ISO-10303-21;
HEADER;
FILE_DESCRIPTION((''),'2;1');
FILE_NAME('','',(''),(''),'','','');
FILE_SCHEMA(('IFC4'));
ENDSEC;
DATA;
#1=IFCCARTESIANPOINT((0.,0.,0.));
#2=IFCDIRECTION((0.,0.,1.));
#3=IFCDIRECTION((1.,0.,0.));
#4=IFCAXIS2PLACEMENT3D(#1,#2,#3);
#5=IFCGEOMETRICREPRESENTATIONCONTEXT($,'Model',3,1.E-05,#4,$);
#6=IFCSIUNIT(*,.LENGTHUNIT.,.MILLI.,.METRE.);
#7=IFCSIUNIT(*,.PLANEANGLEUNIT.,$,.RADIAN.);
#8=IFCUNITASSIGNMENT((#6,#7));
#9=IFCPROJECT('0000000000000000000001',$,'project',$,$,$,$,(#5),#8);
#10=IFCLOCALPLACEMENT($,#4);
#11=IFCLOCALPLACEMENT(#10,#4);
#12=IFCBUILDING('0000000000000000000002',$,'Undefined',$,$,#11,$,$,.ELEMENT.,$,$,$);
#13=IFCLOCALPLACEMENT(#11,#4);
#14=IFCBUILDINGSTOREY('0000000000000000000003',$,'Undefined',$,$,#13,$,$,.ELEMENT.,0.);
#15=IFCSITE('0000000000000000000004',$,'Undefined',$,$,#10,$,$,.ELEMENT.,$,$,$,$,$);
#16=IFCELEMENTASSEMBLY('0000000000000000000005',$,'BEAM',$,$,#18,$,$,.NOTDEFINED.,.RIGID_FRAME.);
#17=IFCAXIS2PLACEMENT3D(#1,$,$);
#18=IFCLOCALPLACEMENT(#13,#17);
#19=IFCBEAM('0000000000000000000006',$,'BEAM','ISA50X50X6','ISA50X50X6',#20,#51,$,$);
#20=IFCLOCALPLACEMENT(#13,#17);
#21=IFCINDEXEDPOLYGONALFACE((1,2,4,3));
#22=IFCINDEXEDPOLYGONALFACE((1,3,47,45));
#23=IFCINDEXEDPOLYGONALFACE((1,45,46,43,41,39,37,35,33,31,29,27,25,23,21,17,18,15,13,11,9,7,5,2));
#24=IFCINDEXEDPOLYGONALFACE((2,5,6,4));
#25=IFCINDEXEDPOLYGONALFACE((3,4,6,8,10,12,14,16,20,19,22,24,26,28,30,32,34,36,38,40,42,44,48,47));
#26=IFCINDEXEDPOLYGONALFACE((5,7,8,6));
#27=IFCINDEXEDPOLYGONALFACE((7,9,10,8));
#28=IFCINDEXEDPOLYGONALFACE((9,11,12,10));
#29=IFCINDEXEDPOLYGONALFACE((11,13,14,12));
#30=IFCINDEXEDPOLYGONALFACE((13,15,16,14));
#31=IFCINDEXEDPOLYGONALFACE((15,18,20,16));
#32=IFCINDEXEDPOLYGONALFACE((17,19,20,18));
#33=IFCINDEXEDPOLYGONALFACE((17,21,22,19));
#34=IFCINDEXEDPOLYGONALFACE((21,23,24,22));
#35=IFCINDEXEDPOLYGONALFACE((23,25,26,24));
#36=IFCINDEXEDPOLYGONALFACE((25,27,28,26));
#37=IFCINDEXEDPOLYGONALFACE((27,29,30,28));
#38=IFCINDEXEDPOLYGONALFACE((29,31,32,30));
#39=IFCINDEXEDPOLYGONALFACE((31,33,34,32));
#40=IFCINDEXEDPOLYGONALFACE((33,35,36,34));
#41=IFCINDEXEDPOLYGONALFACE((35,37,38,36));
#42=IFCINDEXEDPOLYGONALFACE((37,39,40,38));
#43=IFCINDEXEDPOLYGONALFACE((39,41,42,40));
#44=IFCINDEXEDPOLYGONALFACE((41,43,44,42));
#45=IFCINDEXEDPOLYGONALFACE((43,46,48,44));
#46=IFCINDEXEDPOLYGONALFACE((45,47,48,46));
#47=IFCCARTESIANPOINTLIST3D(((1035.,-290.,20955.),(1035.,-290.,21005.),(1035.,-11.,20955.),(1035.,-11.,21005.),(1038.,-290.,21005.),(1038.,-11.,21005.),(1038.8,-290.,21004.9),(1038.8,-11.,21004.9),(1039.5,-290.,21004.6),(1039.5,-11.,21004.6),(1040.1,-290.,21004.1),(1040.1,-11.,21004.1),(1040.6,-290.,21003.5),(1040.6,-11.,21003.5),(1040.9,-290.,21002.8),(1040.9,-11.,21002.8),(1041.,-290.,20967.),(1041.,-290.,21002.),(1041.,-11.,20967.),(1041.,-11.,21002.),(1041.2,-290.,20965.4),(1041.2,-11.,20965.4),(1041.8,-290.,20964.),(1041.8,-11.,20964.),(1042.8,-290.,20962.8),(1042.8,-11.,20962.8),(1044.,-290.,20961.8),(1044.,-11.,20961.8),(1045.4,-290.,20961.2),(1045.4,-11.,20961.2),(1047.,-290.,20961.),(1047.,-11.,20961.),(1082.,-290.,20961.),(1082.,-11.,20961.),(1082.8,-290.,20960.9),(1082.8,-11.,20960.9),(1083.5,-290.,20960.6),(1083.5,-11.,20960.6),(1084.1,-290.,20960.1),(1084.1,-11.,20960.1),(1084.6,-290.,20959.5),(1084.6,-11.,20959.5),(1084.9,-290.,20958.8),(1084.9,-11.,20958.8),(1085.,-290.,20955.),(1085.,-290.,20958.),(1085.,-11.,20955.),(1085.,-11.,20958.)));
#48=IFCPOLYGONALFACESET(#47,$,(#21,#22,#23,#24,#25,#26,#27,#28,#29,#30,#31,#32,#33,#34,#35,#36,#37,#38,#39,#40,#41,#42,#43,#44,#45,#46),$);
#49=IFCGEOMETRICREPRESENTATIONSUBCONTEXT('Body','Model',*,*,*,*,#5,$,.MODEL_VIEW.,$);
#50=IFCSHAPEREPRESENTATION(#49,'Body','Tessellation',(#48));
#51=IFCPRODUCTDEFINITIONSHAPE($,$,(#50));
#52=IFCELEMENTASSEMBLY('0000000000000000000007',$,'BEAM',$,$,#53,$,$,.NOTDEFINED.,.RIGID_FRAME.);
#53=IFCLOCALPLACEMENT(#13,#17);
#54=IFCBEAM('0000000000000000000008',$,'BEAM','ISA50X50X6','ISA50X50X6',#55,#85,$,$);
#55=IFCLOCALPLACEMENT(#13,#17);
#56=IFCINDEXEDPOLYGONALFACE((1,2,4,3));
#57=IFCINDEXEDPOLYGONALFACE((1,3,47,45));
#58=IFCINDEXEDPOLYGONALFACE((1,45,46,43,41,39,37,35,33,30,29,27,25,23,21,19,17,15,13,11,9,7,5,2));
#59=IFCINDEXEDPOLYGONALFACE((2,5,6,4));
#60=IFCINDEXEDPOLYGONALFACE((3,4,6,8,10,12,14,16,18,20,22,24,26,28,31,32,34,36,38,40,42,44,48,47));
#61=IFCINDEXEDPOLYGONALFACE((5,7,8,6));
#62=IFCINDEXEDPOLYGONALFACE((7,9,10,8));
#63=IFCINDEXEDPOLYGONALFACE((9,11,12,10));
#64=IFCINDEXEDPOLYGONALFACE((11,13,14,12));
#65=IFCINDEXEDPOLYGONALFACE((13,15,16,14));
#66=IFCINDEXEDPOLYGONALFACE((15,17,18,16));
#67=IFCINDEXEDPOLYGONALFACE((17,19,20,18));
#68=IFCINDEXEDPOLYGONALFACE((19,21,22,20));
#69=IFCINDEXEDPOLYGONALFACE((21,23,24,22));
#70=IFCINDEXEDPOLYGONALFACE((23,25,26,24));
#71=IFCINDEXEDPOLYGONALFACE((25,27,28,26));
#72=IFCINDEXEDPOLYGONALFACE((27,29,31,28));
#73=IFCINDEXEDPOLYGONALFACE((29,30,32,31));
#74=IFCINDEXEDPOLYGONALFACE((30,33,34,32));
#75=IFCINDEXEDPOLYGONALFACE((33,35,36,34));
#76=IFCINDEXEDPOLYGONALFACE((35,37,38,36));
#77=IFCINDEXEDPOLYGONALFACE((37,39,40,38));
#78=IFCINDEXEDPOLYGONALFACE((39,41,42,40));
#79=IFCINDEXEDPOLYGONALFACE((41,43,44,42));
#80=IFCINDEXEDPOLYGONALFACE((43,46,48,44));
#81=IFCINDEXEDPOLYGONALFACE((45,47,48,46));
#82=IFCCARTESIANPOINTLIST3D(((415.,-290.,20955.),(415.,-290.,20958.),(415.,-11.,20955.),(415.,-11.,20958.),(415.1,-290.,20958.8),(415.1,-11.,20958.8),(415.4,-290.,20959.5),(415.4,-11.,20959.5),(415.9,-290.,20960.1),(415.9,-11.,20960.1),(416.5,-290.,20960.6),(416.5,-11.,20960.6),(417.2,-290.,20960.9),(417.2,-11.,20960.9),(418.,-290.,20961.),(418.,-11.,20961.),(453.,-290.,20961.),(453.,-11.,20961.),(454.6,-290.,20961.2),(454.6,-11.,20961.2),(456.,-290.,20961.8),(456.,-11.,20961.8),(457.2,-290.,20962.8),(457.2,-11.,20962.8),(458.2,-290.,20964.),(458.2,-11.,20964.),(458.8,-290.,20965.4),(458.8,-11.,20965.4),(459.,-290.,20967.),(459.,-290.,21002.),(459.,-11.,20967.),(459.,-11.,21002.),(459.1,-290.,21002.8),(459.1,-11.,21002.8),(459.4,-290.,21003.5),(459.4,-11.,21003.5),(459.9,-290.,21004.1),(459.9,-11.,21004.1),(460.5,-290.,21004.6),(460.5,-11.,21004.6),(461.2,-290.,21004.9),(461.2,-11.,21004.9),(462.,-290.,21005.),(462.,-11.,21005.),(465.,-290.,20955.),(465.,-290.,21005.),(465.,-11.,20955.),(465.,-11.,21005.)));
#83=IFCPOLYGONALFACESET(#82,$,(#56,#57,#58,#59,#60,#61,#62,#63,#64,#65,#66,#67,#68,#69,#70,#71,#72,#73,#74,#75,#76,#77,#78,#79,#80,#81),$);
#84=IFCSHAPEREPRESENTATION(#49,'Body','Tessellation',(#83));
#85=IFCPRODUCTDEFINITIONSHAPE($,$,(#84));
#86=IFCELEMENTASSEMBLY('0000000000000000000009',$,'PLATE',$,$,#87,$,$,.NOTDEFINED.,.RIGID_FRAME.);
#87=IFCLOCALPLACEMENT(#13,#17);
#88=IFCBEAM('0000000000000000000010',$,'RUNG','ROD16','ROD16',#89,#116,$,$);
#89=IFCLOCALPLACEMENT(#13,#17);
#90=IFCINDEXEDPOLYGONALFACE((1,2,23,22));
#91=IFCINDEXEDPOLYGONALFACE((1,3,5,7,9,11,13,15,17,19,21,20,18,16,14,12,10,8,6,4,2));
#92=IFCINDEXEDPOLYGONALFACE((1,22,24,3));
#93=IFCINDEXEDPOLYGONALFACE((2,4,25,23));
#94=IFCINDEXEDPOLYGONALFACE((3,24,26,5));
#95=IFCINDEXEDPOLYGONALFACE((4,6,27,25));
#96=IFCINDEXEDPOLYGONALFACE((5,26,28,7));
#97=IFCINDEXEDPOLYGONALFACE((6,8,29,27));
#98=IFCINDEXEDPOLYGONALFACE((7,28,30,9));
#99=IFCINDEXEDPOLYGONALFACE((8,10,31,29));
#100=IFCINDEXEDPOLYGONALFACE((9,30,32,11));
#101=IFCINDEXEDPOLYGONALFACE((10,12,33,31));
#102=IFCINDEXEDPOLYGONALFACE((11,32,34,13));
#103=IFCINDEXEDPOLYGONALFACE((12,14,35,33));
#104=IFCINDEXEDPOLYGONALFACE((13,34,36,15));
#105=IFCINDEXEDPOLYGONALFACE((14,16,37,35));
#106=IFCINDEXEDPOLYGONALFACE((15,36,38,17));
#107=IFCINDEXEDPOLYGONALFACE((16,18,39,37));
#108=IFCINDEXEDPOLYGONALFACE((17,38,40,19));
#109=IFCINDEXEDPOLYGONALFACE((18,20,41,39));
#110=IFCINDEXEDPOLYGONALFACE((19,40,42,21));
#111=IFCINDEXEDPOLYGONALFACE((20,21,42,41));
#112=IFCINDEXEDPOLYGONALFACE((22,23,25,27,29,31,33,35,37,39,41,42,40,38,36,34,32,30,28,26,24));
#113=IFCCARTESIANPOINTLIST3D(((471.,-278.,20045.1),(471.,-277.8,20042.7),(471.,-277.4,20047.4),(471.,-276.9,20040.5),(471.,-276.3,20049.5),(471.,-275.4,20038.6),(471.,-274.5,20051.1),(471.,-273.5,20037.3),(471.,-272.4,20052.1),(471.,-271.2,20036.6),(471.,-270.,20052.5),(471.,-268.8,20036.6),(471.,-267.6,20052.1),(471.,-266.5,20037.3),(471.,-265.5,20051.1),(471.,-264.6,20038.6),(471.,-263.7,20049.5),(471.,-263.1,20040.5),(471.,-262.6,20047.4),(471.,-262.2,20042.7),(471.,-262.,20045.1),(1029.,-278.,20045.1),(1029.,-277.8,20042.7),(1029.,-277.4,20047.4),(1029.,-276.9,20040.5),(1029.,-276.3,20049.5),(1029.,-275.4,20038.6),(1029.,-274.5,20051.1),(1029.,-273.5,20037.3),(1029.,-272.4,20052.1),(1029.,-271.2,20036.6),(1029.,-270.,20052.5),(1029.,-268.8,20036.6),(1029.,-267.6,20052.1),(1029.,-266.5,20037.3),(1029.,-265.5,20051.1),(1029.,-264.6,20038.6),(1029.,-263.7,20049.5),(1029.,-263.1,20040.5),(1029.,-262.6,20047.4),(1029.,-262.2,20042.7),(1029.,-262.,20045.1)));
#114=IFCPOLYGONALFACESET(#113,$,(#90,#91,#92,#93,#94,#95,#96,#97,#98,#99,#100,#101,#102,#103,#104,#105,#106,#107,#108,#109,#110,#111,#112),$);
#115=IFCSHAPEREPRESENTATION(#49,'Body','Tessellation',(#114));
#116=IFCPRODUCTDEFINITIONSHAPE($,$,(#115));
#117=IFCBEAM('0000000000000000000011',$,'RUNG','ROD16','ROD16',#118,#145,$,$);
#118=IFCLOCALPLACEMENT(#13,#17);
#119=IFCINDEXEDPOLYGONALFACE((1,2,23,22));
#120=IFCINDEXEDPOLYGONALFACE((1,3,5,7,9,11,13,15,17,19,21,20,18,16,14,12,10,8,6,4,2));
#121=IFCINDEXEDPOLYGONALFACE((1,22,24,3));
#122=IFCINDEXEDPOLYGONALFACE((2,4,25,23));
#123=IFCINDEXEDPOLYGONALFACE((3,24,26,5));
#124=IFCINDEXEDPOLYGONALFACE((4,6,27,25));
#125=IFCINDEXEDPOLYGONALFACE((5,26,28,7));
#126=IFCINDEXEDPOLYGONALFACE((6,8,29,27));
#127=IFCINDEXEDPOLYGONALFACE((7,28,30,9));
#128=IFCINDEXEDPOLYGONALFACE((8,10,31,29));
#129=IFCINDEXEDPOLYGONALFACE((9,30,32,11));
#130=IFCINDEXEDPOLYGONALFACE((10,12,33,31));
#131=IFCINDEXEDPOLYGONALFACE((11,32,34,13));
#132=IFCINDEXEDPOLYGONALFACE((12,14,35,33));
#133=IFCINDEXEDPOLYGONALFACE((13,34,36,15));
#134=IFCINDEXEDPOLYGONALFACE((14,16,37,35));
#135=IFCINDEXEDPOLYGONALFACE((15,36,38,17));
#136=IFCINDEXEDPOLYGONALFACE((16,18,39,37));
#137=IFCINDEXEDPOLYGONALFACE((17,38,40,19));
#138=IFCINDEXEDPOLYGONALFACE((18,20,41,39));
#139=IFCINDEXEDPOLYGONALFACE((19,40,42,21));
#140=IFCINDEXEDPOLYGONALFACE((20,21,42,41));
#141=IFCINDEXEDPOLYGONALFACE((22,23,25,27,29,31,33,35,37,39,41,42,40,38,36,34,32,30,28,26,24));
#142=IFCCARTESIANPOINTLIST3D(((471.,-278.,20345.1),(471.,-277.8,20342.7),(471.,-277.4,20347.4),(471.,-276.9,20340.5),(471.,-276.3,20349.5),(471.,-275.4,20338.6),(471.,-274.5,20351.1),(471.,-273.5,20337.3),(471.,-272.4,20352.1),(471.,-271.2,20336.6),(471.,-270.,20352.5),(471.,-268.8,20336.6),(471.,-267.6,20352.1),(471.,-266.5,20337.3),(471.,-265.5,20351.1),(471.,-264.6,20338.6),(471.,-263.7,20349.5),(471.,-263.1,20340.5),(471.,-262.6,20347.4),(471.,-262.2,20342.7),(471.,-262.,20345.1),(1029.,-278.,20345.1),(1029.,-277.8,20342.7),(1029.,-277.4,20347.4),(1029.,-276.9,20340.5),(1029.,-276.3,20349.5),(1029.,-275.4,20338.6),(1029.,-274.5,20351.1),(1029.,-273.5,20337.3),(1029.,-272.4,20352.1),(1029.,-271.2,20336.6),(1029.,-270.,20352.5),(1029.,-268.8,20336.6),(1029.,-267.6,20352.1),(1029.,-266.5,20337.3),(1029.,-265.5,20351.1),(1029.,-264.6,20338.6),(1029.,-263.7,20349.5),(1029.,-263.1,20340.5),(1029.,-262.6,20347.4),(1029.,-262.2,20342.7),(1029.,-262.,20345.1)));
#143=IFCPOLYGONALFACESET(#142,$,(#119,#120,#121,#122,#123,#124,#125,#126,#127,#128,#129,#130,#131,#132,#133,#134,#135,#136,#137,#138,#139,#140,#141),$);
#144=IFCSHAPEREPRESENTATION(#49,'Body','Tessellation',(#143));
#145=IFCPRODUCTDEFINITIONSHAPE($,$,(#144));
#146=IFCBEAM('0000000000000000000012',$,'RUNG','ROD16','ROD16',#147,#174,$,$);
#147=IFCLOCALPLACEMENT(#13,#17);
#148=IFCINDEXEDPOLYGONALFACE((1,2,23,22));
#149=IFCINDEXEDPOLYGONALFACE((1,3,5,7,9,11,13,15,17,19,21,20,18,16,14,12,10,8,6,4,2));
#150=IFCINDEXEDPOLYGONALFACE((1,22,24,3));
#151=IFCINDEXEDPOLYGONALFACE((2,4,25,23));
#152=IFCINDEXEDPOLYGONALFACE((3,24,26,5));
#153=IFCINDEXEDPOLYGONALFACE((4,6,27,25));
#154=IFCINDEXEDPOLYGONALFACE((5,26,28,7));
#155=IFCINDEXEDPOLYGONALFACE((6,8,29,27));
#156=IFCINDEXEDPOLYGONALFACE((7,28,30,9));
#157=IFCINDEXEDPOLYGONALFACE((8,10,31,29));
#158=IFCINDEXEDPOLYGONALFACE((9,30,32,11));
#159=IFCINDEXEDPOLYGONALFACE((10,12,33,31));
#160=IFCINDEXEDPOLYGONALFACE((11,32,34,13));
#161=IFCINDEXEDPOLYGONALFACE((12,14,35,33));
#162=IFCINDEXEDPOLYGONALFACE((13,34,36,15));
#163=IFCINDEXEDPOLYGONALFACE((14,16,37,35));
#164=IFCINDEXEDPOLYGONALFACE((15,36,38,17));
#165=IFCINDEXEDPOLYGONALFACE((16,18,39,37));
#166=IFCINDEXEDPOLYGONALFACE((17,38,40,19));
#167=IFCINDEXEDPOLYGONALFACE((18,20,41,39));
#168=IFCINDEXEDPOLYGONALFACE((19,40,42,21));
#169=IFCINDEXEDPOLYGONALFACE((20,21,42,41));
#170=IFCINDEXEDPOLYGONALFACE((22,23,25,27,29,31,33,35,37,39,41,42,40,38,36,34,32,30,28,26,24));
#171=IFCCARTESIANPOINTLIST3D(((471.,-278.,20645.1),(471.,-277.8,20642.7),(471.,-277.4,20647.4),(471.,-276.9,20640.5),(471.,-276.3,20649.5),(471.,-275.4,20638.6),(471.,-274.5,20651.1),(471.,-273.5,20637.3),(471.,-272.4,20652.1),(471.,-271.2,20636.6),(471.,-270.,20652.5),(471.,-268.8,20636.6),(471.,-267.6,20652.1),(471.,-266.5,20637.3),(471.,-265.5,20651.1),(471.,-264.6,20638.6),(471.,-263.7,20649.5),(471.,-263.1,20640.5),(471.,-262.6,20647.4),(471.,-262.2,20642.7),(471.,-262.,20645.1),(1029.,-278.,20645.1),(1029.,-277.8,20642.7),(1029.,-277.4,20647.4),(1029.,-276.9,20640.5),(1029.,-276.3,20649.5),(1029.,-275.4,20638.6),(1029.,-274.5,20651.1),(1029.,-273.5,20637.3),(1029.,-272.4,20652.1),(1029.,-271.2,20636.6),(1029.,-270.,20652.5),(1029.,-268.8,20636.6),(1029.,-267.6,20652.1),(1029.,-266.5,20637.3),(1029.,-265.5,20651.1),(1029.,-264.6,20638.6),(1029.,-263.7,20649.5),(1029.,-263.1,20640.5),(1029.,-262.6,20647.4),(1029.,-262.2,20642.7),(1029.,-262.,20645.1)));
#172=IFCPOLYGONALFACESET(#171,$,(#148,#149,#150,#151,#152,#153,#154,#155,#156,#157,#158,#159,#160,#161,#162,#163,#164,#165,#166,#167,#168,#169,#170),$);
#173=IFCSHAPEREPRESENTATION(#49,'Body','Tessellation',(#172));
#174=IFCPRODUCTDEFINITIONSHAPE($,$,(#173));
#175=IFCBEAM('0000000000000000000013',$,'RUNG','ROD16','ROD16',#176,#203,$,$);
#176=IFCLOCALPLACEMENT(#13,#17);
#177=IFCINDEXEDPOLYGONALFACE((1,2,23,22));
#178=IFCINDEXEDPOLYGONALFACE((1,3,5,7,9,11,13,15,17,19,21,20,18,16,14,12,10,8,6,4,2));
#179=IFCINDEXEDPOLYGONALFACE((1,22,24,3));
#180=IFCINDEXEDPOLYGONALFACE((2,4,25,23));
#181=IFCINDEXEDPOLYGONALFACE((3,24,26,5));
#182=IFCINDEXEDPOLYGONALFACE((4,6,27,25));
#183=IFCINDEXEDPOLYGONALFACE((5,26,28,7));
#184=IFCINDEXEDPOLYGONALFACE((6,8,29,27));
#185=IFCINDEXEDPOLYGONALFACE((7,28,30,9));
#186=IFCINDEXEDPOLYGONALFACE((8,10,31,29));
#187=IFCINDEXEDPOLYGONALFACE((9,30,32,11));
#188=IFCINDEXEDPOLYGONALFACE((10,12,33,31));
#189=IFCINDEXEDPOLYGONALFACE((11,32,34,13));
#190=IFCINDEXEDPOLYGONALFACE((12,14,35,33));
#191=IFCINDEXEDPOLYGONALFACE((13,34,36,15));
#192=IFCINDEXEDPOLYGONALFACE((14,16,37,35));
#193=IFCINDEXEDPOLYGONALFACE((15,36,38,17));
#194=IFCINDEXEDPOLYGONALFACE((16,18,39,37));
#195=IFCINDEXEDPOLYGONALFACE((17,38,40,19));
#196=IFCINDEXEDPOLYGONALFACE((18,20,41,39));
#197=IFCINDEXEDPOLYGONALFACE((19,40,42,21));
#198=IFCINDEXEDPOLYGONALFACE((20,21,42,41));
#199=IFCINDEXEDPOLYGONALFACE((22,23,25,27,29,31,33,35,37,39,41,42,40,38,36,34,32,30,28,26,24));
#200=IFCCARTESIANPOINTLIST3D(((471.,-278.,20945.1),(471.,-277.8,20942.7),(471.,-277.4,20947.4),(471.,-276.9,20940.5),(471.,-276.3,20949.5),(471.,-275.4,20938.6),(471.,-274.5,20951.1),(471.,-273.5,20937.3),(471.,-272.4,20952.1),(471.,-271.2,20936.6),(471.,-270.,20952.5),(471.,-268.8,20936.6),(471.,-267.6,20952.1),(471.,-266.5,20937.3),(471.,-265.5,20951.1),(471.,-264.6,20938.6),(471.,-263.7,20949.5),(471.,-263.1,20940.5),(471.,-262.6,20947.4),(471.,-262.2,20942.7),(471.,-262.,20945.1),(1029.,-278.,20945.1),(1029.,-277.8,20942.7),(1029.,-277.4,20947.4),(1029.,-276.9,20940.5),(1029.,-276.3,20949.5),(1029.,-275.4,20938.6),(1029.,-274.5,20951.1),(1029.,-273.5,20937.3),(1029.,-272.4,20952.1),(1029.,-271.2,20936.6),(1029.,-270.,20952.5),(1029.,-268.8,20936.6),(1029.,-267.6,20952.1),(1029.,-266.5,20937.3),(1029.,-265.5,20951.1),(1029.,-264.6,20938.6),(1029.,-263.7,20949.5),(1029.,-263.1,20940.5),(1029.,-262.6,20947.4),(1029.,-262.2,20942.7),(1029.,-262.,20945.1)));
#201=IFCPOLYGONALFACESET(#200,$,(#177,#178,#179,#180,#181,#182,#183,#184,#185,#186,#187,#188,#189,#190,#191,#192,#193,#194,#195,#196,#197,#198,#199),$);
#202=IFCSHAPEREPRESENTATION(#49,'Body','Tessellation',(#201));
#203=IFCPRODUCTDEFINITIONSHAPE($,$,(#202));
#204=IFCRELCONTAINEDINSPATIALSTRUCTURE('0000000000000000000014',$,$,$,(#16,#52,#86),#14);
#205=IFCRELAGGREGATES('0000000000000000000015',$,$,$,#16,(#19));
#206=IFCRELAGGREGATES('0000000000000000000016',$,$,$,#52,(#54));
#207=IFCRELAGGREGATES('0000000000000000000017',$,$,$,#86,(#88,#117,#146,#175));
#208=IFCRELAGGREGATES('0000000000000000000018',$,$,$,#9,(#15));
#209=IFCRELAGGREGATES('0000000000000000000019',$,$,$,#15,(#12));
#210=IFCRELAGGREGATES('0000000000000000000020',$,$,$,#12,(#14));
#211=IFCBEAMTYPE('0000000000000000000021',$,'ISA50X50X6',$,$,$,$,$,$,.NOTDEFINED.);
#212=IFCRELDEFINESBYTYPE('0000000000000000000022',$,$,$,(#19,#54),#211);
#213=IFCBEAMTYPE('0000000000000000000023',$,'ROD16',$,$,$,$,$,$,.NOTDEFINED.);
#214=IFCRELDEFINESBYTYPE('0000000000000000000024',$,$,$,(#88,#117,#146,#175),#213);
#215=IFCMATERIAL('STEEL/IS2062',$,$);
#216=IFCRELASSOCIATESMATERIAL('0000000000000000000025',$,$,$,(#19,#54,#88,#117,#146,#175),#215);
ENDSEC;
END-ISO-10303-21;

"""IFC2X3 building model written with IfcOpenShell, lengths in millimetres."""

from ifc_helpers import new_model, si_unit, frame, origin_with_axes, origin_2d_with_axis, place, context, subcontext, project, spatial, circle, l_section, extrude, material, type_object, element, aggregate, save


model = new_model("IFC2X3")

# Units and contexts
model_context = context("Model", 3, precision=1e-05, world=origin_with_axes())
body_context = subcontext(model_context, "Body", "Model", "MODEL_VIEW")
ifc_project = project(units=[si_unit("LENGTHUNIT", "METRE", prefix="MILLI"), si_unit("PLANEANGLEUNIT", "RADIAN")], contexts=[model_context])

# Site, building, storey
site_placement = place(None, origin_with_axes())
site = spatial("IfcSite", under=ifc_project, at=site_placement, Name="Undefined", CompositionType="ELEMENT")
building_placement = place(site_placement, origin_with_axes())
building = spatial("IfcBuilding", under=site, at=building_placement, Name="Undefined", CompositionType="ELEMENT")
storey_placement = place(building_placement, origin_with_axes())
storey = spatial("IfcBuildingStorey", under=building, at=storey_placement, Name="Undefined", CompositionType="ELEMENT", Elevation=0.0)

# Element assemblies, beams
assembly_1_placement = place(storey_placement, origin_with_axes())
assembly_1 = element("IfcElementAssembly", 1, at=assembly_1_placement, inside=storey, Name="BEAM", AssemblyPlace="NOTDEFINED", PredefinedType="RIGID_FRAME")
ifc_material = material(Name="STEEL/IS2062")
beam_type_1 = type_object("IfcBeamType", Name="ISA50X50X6", PredefinedType="NOTDEFINED")
beam_1_placement = place(assembly_1_placement, frame((1060.0, -290.0, 20980.0), z_axis=(0.0, 0.0, 1.0), x_axis=(0.0, 1.0, 0.0)))
beam_1 = element("IfcBeam", 2, at=beam_1_placement, type_object=beam_type_1, material=ifc_material, Name="BEAM", Description="ISA50X50X6", ObjectType="ISA50X50X6", context=body_context, shape_type="SweptSolid", body=[
    extrude(l_section(Depth=50.0, Width=50.0, Thickness=6.0, FilletRadius=6.0, EdgeRadius=3.0, at=origin_2d_with_axis()), frame((279.0, 0.0, 0.0), z_axis=(-1.0, 0.0, 0.0), x_axis=(0.0, -1.0, 0.0)), (0.0, 0.0, 1.0), 279.0),
])
aggregate(assembly_1, [beam_1])
assembly_2_placement = place(storey_placement, origin_with_axes())
assembly_2 = element("IfcElementAssembly", 3, at=assembly_2_placement, inside=storey, Name="BEAM", AssemblyPlace="NOTDEFINED", PredefinedType="RIGID_FRAME")
beam_2_placement = place(assembly_2_placement, frame((440.0, -11.0, 20980.0), z_axis=(0.0, 0.0, 1.0), x_axis=(0.0, -1.0, 0.0)))
beam_2 = element("IfcBeam", 4, at=beam_2_placement, type_object=beam_type_1, material=ifc_material, Name="BEAM", Description="ISA50X50X6", ObjectType="ISA50X50X6", context=body_context, shape_type="SweptSolid", body=[
    extrude(l_section(Depth=50.0, Width=50.0, Thickness=6.0, FilletRadius=6.0, EdgeRadius=3.0, at=origin_2d_with_axis()), frame((279.0, 0.0, 0.0), z_axis=(-1.0, 0.0, 0.0), x_axis=(0.0, -1.0, 0.0)), (0.0, 0.0, 1.0), 279.0),
])
aggregate(assembly_2, [beam_2])

# Element assembly, beams
assembly_3_placement = place(storey_placement, origin_with_axes())
assembly_3 = element("IfcElementAssembly", 5, at=assembly_3_placement, inside=storey, Name="PLATE", AssemblyPlace="NOTDEFINED", PredefinedType="RIGID_FRAME")
beam_type_2 = type_object("IfcBeamType", Name="ROD16", PredefinedType="NOTDEFINED")
beam_3_placement = place(assembly_3_placement, frame((471.0, -270.0, 20044.5), z_axis=(0.0, 1.0, 0.0), x_axis=(1.0, 0.0, 0.0)))
beam_3 = element("IfcBeam", 6, at=beam_3_placement, type_object=beam_type_2, material=ifc_material, Name="RUNG", Description="ROD16", ObjectType="ROD16", context=body_context, shape_type="SweptSolid", body=[
    extrude(circle(Radius=8.0, at=origin_2d_with_axis()), frame((558.0, 0.0, 0.0), z_axis=(-1.0, 0.0, 0.0), x_axis=(0.0, -1.0, 0.0)), (0.0, 0.0, 1.0), 558.0),
])
beam_4_placement = place(assembly_3_placement, frame((471.0, -270.0, 20344.5), z_axis=(0.0, 1.0, 0.0), x_axis=(1.0, 0.0, 0.0)))
beam_4 = element("IfcBeam", 7, at=beam_4_placement, type_object=beam_type_2, material=ifc_material, Name="RUNG", Description="ROD16", ObjectType="ROD16", context=body_context, shape_type="SweptSolid", body=[
    extrude(circle(Radius=8.0, at=origin_2d_with_axis()), frame((558.0, 0.0, 0.0), z_axis=(-1.0, 0.0, 0.0), x_axis=(0.0, -1.0, 0.0)), (0.0, 0.0, 1.0), 558.0),
])
beam_5_placement = place(assembly_3_placement, frame((471.0, -270.0, 20644.5), z_axis=(0.0, 1.0, 0.0), x_axis=(1.0, 0.0, 0.0)))
beam_5 = element("IfcBeam", 8, at=beam_5_placement, type_object=beam_type_2, material=ifc_material, Name="RUNG", Description="ROD16", ObjectType="ROD16", context=body_context, shape_type="SweptSolid", body=[
    extrude(circle(Radius=8.0, at=origin_2d_with_axis()), frame((558.0, 0.0, 0.0), z_axis=(-1.0, 0.0, 0.0), x_axis=(0.0, -1.0, 0.0)), (0.0, 0.0, 1.0), 558.0),
])
beam_6_placement = place(assembly_3_placement, frame((471.0, -270.0, 20944.5), z_axis=(0.0, 1.0, 0.0), x_axis=(1.0, 0.0, 0.0)))
beam_6 = element("IfcBeam", 9, at=beam_6_placement, type_object=beam_type_2, material=ifc_material, Name="RUNG", Description="ROD16", ObjectType="ROD16", context=body_context, shape_type="SweptSolid", body=[
    extrude(circle(Radius=8.0, at=origin_2d_with_axis()), frame((558.0, 0.0, 0.0), z_axis=(-1.0, 0.0, 0.0), x_axis=(0.0, -1.0, 0.0)), (0.0, 0.0, 1.0), 558.0),
])
aggregate(assembly_3, [beam_3, beam_4, beam_5, beam_6])

save(model, "model.ifc")
